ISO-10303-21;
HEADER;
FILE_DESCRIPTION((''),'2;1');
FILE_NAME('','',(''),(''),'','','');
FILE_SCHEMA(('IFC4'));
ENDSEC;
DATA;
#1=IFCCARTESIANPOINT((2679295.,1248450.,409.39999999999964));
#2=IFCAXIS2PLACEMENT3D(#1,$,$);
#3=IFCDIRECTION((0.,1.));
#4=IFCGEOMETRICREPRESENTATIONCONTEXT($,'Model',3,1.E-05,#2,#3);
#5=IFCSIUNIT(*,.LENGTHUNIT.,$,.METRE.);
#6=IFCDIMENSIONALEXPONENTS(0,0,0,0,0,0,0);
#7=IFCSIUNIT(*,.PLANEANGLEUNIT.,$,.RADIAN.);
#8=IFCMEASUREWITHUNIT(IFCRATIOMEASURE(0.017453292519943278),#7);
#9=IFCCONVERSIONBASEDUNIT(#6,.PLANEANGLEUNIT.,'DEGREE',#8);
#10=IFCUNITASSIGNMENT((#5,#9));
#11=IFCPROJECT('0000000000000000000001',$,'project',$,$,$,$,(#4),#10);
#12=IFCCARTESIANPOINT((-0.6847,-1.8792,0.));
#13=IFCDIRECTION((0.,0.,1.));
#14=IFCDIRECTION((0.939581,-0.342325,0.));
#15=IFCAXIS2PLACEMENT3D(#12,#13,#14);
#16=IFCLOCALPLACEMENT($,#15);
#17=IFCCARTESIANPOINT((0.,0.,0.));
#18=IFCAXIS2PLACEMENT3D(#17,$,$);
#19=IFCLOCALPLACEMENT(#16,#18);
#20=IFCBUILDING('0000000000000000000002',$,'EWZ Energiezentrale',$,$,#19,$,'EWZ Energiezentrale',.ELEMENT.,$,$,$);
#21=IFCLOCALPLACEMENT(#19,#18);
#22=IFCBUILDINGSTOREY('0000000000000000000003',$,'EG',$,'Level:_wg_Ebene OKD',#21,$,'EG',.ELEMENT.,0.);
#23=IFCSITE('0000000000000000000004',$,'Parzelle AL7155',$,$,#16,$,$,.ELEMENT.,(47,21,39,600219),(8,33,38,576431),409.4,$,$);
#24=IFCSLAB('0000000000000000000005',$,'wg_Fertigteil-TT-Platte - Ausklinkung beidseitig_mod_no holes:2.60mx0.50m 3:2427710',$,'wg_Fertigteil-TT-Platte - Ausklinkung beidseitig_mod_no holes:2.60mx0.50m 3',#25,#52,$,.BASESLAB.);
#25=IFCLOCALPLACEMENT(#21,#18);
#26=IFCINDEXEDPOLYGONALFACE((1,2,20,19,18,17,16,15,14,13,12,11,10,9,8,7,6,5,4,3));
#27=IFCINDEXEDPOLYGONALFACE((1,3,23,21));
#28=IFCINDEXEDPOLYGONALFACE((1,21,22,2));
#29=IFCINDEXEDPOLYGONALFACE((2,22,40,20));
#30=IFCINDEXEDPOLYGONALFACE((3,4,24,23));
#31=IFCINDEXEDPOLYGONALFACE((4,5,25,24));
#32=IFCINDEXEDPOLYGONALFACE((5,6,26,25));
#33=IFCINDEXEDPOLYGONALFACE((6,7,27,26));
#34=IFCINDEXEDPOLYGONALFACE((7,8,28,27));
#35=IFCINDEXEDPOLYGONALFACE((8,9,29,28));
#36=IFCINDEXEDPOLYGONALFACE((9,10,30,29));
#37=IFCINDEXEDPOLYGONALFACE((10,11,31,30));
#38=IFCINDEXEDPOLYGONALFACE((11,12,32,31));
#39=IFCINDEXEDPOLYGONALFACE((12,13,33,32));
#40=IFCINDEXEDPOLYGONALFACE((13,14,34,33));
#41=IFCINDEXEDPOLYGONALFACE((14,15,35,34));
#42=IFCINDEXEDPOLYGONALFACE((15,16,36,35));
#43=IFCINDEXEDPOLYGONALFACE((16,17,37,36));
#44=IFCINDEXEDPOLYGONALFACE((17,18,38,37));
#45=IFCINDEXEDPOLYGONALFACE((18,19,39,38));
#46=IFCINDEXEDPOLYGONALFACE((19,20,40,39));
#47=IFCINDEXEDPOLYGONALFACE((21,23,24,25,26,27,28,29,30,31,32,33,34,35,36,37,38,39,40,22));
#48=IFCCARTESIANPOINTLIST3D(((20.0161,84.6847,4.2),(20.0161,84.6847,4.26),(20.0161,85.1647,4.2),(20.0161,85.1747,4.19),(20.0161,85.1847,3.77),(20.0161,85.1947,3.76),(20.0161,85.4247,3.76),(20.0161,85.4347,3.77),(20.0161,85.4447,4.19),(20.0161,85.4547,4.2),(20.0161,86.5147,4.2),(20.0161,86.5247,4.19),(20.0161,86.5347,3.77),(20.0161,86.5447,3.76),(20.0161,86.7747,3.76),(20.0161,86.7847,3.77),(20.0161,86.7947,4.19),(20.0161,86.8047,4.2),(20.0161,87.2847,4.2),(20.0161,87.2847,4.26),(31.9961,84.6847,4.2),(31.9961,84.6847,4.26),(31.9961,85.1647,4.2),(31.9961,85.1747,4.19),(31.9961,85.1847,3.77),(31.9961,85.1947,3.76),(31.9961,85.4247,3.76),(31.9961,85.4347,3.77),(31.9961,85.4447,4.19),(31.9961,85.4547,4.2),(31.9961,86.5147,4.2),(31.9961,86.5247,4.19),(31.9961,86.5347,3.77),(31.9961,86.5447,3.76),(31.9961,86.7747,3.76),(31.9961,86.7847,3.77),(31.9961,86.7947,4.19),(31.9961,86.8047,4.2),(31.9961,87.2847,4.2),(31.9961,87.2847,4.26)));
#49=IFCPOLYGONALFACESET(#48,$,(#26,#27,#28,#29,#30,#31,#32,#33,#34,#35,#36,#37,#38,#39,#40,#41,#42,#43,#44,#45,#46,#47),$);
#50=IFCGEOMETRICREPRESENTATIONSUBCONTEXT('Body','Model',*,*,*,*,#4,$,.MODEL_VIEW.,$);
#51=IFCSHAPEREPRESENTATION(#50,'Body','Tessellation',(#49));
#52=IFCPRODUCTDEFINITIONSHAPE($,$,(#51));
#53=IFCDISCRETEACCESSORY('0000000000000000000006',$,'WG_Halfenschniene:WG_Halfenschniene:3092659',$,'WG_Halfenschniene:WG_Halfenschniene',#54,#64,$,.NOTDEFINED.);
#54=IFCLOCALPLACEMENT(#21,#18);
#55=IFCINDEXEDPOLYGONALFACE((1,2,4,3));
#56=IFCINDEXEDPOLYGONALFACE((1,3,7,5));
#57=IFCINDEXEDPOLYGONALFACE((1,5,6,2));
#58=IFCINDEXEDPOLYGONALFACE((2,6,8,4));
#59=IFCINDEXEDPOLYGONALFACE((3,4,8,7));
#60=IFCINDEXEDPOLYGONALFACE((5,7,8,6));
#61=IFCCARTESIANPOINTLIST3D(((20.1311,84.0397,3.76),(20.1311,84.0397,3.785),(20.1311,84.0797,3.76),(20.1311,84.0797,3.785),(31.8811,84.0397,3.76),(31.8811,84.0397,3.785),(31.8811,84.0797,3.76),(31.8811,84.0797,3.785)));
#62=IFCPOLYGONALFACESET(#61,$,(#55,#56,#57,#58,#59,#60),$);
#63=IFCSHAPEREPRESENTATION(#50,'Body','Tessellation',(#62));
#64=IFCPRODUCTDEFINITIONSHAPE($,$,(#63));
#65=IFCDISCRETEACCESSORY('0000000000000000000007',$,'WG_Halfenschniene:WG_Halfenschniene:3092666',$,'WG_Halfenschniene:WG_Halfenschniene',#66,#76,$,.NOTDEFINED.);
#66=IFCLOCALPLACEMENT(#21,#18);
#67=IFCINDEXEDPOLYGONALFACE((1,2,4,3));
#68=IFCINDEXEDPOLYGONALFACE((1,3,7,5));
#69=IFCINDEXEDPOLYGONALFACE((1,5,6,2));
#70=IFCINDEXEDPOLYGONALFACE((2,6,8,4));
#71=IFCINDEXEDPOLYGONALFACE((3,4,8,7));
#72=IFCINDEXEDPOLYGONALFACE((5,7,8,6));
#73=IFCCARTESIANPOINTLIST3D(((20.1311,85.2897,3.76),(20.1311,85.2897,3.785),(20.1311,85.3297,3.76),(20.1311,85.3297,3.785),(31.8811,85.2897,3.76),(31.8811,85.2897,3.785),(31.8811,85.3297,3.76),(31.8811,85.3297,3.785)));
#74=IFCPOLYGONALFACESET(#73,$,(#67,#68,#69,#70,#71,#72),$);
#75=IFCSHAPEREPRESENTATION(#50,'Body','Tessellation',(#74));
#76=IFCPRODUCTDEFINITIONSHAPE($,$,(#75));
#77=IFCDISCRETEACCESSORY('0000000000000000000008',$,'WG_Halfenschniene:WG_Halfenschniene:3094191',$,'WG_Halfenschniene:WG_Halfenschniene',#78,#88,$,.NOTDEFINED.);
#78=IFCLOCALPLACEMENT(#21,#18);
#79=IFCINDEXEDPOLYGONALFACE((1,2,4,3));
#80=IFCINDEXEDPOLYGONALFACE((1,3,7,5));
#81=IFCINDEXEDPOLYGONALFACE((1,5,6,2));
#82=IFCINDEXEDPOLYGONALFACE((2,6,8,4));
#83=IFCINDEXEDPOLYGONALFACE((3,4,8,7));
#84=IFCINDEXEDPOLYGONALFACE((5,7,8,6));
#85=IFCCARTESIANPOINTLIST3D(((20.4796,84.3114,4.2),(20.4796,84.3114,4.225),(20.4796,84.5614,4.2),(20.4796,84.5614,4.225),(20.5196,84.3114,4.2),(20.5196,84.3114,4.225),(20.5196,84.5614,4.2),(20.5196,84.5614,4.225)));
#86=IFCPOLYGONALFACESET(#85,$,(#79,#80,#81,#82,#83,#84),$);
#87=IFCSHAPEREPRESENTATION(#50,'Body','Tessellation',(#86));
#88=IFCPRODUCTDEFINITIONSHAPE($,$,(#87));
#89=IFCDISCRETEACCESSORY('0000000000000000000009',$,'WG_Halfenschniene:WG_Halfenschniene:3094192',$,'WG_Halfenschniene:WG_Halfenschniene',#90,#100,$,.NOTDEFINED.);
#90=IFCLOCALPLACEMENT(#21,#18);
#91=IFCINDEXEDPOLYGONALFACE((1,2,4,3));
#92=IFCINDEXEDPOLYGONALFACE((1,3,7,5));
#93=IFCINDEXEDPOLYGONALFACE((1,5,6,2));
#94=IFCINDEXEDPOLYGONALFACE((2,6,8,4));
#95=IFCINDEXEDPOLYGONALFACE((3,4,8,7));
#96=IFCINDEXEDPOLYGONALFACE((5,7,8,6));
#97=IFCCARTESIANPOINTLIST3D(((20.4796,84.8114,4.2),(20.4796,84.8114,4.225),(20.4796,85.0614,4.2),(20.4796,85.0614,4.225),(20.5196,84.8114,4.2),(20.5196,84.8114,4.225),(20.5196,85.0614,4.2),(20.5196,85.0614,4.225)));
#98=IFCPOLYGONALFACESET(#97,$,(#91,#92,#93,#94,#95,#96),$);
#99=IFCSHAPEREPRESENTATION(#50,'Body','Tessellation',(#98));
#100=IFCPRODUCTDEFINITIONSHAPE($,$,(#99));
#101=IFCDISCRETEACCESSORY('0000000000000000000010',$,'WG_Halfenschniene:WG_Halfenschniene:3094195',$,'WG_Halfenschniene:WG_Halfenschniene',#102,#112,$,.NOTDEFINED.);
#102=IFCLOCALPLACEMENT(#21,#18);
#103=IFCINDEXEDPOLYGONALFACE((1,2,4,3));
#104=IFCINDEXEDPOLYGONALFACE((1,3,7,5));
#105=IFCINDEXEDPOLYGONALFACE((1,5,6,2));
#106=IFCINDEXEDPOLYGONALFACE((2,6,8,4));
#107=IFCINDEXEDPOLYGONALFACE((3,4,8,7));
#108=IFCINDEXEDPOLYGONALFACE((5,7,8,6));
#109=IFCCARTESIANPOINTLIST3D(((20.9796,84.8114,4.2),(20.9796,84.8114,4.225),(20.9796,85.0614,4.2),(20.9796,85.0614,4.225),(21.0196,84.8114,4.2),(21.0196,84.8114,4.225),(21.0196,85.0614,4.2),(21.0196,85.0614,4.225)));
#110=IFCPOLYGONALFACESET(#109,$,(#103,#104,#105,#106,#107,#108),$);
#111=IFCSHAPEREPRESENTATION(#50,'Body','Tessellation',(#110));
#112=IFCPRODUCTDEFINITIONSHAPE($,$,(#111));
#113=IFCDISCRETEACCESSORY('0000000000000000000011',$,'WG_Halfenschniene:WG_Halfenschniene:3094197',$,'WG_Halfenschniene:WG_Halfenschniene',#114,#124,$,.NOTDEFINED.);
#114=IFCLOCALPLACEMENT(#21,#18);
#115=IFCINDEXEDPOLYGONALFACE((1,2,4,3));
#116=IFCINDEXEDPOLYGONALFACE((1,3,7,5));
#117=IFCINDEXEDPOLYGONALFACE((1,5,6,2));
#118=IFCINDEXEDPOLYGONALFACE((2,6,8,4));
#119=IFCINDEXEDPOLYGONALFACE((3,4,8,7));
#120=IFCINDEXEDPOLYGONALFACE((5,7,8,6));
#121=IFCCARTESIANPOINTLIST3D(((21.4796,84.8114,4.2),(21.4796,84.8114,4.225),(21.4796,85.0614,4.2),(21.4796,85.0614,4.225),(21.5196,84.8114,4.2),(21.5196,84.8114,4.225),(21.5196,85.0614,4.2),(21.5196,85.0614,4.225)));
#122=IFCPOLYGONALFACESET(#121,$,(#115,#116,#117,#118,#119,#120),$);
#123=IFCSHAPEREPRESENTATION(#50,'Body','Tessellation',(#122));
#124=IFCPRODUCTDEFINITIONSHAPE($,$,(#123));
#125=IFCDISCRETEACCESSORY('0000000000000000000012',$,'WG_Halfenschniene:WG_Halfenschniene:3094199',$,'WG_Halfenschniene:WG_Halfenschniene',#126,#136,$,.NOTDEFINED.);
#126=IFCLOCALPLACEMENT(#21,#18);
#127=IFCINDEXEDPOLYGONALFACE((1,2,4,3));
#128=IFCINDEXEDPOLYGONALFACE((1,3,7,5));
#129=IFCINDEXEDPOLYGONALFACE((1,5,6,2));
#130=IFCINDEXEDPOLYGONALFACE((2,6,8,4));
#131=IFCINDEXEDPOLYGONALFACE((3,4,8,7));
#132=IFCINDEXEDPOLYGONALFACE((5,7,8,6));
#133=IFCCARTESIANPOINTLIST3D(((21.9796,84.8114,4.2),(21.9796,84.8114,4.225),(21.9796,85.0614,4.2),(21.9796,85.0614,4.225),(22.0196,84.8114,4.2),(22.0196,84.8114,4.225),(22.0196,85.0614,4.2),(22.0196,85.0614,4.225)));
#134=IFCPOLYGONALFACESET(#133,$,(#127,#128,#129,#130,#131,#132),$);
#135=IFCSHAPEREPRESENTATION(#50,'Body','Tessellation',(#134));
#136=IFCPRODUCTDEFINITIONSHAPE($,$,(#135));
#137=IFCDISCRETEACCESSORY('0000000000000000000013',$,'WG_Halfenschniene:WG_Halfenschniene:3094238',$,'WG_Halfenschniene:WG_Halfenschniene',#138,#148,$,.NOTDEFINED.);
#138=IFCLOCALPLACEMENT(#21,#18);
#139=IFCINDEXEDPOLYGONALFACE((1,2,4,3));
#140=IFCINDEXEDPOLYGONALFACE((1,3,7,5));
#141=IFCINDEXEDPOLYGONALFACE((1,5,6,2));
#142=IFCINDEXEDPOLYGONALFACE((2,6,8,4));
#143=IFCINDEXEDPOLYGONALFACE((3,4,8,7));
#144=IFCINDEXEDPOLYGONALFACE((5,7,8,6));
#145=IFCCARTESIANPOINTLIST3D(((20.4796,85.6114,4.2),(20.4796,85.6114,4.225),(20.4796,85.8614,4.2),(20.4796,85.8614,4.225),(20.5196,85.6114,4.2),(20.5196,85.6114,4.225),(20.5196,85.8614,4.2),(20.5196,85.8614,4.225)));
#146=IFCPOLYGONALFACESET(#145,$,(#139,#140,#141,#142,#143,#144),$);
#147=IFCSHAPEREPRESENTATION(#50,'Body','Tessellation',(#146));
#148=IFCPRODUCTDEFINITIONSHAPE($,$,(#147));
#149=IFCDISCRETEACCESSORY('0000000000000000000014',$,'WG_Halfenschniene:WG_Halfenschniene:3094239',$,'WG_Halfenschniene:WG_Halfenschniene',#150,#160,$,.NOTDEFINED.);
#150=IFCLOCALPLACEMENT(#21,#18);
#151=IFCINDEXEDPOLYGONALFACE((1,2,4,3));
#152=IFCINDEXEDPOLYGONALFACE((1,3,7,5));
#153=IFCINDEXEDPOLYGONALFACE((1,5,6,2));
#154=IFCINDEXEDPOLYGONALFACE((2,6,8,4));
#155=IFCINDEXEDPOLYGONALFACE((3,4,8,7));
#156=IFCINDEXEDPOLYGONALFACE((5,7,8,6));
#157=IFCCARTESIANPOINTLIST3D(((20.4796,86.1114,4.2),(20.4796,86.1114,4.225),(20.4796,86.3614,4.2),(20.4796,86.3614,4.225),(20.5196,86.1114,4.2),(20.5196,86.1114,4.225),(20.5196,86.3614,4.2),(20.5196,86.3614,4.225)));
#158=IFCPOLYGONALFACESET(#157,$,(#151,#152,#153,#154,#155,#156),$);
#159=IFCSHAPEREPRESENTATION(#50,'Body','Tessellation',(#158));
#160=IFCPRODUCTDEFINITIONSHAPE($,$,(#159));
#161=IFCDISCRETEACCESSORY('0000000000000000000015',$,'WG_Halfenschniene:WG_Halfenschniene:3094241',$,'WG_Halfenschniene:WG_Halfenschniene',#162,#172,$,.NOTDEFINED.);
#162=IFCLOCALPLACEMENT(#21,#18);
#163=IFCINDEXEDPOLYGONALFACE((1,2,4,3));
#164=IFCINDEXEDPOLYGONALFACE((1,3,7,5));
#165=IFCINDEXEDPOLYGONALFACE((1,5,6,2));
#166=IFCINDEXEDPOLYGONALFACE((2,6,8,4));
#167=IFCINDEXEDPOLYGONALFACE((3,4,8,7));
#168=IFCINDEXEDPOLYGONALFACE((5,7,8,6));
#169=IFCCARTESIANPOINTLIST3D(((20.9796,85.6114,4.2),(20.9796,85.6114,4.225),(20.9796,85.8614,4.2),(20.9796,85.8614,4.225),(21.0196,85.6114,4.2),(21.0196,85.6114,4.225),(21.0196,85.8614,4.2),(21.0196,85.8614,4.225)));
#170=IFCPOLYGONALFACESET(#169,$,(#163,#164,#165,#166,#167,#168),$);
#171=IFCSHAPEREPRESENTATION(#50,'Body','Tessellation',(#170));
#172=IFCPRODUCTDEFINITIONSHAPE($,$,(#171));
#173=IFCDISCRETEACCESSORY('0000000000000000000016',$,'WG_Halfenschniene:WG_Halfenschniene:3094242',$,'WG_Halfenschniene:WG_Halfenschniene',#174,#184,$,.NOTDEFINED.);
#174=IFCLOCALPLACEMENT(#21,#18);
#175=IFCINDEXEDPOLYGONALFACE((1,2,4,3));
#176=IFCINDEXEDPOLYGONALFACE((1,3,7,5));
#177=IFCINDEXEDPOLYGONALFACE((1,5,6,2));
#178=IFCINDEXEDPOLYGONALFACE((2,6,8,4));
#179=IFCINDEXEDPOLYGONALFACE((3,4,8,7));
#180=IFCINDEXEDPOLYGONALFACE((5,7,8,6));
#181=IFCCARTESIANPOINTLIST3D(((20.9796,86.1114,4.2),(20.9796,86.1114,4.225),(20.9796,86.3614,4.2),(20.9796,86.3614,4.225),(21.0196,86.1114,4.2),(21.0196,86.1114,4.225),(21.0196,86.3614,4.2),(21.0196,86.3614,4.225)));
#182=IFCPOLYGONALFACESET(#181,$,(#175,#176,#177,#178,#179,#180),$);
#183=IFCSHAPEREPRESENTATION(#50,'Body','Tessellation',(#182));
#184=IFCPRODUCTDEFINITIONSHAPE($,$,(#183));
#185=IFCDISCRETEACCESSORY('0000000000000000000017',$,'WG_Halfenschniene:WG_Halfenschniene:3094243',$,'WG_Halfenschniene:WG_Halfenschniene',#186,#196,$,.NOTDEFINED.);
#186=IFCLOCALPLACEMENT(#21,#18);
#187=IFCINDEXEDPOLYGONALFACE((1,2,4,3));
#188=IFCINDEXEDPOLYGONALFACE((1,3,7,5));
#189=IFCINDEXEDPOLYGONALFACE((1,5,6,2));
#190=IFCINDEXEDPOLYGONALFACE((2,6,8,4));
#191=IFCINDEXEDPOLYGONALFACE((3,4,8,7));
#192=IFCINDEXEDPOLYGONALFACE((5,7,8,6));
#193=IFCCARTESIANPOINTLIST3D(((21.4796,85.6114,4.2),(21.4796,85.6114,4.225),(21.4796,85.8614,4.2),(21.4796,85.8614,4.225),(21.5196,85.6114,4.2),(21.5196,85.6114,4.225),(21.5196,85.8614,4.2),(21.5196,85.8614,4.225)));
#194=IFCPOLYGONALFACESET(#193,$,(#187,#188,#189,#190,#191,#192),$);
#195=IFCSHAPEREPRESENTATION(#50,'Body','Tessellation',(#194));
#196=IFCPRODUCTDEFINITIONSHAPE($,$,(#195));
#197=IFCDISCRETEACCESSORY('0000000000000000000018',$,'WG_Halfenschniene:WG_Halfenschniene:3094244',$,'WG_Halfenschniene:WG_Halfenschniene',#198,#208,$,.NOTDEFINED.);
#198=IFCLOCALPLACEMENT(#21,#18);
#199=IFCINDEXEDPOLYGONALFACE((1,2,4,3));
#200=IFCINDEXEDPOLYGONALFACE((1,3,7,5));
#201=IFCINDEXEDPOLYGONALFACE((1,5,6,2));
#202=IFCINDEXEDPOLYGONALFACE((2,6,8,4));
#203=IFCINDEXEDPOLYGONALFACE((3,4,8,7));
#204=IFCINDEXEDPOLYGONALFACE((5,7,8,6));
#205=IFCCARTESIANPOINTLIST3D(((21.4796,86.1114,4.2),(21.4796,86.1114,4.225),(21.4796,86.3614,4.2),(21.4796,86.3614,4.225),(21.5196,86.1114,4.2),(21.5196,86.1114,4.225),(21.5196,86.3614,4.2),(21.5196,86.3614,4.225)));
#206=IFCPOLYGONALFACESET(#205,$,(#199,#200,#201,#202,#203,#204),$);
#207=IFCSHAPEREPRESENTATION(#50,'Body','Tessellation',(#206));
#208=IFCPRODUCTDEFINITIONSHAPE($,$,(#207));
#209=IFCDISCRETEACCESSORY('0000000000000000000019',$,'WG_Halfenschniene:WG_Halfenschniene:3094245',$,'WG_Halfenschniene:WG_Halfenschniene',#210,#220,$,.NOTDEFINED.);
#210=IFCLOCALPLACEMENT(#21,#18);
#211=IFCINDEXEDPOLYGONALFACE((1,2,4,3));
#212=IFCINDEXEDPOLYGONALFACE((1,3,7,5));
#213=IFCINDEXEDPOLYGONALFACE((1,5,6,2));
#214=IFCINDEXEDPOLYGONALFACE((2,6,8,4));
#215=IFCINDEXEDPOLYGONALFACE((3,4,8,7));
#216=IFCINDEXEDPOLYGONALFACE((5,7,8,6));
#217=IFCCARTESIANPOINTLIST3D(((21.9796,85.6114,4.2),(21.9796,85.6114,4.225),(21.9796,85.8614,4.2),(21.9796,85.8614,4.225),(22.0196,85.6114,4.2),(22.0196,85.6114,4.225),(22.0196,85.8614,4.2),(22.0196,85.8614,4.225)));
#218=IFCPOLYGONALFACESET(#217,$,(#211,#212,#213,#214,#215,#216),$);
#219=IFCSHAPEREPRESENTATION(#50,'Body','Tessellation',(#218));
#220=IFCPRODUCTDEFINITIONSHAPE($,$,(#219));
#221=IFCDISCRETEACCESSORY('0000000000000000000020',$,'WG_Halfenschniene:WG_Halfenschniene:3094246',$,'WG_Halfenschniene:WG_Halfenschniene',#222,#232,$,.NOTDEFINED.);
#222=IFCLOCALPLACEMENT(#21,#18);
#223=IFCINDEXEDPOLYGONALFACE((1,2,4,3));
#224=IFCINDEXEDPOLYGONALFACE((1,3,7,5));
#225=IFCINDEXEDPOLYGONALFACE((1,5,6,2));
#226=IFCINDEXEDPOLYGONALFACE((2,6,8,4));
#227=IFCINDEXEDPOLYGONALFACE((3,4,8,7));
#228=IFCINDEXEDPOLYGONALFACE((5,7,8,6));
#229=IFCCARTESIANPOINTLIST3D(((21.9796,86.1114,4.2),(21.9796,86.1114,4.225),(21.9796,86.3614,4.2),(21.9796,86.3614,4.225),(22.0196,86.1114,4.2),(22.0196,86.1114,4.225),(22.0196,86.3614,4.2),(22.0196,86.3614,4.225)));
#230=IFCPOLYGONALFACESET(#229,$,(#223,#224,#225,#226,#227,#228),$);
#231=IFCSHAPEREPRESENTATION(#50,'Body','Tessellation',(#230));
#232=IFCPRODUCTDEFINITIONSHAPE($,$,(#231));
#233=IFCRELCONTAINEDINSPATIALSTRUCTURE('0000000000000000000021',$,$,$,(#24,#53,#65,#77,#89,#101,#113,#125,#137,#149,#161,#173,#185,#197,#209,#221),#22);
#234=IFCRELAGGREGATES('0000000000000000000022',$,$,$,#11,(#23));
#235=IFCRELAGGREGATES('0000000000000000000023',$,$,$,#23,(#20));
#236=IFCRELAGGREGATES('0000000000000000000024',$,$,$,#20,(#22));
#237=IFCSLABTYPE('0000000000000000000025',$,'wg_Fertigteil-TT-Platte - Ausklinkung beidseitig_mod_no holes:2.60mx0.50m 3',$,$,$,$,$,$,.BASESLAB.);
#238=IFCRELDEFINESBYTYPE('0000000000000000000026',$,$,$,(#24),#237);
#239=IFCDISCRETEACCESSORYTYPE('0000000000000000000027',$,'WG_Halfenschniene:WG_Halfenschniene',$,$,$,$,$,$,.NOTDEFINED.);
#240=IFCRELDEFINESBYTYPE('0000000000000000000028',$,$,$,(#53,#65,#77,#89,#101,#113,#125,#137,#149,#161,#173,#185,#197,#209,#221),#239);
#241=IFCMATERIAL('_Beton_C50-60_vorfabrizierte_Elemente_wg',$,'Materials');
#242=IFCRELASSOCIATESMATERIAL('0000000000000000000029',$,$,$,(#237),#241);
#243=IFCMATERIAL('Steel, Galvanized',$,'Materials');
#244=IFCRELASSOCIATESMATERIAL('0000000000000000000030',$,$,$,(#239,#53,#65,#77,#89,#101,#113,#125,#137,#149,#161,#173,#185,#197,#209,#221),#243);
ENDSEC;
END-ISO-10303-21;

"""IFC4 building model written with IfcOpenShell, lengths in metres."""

from ifc_helpers import new_model, entity, si_unit, converted_unit, direction, frame, origin, place, context, subcontext, project, spatial, indexed_curve, outline, extrude, source, transform, mapped, material, type_object, type_shapes, element, save


model = new_model("IFC4")

# Units and contexts
model_context = context("Model", 3, precision=1e-05, world=frame((2679295.0, 1248450.0, 409.39999999999964)), true_north=direction((0.0, 1.0)))
body_context = subcontext(model_context, "Body", "Model", "MODEL_VIEW")
ifc_project = project(units=[si_unit("LENGTHUNIT", "METRE"), converted_unit("PLANEANGLEUNIT", "DEGREE", entity("IfcRatioMeasure", 0.017453292519943278), si_unit("PLANEANGLEUNIT", "RADIAN"), dimensions=[0, 0, 0, 0, 0, 0, 0])], contexts=[model_context])

# Site, building, storey
site_placement = place(None, frame((-0.6847, -1.8792, 0.0), z_axis=(0.0, 0.0, 1.0), x_axis=(0.939581, -0.342325, 0.0)))
site = spatial("IfcSite", under=ifc_project, at=site_placement, Name="Parzelle AL7155", CompositionType="ELEMENT", RefLatitude=(47, 21, 39, 600219), RefLongitude=(8, 33, 38, 576431), RefElevation=409.4)
building_placement = place(site_placement, origin())
building = spatial("IfcBuilding", under=site, at=building_placement, Name="EWZ Energiezentrale", LongName="EWZ Energiezentrale", CompositionType="ELEMENT")
storey_placement = place(building_placement, origin())
storey = spatial("IfcBuildingStorey", under=building, at=storey_placement, Name="EG", ObjectType="Level:_wg_Ebene OKD", LongName="EG", CompositionType="ELEMENT", Elevation=0.0)

# Slab
ifc_material_1 = material(Name="_Beton_C50-60_vorfabrizierte_Elemente_wg", Category="Materials")
slab_type = type_object("IfcSlabType", Name="wg_Fertigteil-TT-Platte - Ausklinkung beidseitig_mod_no holes:2.60mx0.50m 3", PredefinedType="BASESLAB", material=ifc_material_1)
slab_placement = place(storey_placement, frame((20.0161, 84.6847, 3.76), z_axis=(0.0, 0.0, 1.0), x_axis=(1.0, 0.0, 0.0)))
element("IfcSlab", 1, at=slab_placement, inside=storey, type_object=slab_type, Name="wg_Fertigteil-TT-Platte - Ausklinkung beidseitig_mod_no holes:2.60mx0.50m 3:2427710", ObjectType="wg_Fertigteil-TT-Platte - Ausklinkung beidseitig_mod_no holes:2.60mx0.50m 3", PredefinedType="BASESLAB", context=body_context, shape_type="SweptSolid", body=[
    extrude(outline(indexed_curve([(-1.3, -0.23), (1.3, -0.23), (1.3, -0.17), (0.82, -0.17), (0.81, -0.16), (0.8, 0.26), (0.79, 0.27), (0.56, 0.27), (0.55, 0.26), (0.54, -0.16), (0.53, -0.17), (-0.53, -0.17), (-0.54, -0.16), (-0.55, 0.26), (-0.56, 0.27), (-0.79, 0.27), (-0.8, 0.26), (-0.81, -0.16), (-0.82, -0.17), (-1.3, -0.17), (-1.3, -0.23)], self_intersect=False)), frame((0.0, 1.3, 0.27), z_axis=(1.0, 0.0, 0.0), x_axis=(0.0, -1.0, 0.0)), (0.0, 0.0, 1.0), 11.98),
])

# Discrete accessories
ifc_material_2 = material(Name="Steel, Galvanized", Category="Materials")
discrete_accessory_type = type_object("IfcDiscreteAccessoryType", Name="WG_Halfenschniene:WG_Halfenschniene", PredefinedType="NOTDEFINED", material=ifc_material_2)
shared_shape_1 = source(origin(), body_context, "Body", "SweptSolid", [
    extrude(outline(indexed_curve([(-5.875, -0.02), (5.875, -0.02), (5.875, 0.02), (-5.875, 0.02), (-5.875, -0.02)], self_intersect=False)), frame((5.875, 0.0, -0.0125)), (0.0, 0.0, 1.0), 0.025),
])
type_shapes(discrete_accessory_type, [shared_shape_1])
for number, where, z_axis, x_axis, name in (
    (2, (20.1311, 84.0597, 3.7725), (0.0, 0.0, -1.0), (1.0, 0.0, 0.0), "WG_Halfenschniene:WG_Halfenschniene:3092659"),
    (3, (20.1311, 85.3097, 3.7725), (0.0, 0.0, -1.0), (1.0, 0.0, 0.0), "WG_Halfenschniene:WG_Halfenschniene:3092666"),
):
    element("IfcDiscreteAccessory", number, at=place(storey_placement, frame(where, z_axis=z_axis, x_axis=x_axis)), inside=storey, type_object=discrete_accessory_type, material=ifc_material_2, Name=name, ObjectType="WG_Halfenschniene:WG_Halfenschniene", PredefinedType="NOTDEFINED", context=body_context, shape_type="MappedRepresentation", body=[
        mapped(shared_shape_1, transform((0.0, 0.0, 0.0), scale=1.0)),
    ])
shared_shape_2 = source(origin(), body_context, "Body", "SweptSolid", [
    extrude(outline(indexed_curve([(-0.125, -0.02), (0.125, -0.02), (0.125, 0.02), (-0.125, 0.02), (-0.125, -0.02)], self_intersect=False)), frame((0.125, 0.0, -0.0125)), (0.0, 0.0, 1.0), 0.025),
])
for number, where, z_axis, x_axis, name in (
    (4, (20.4996, 84.3114, 4.2125), (0.0, 0.0, -1.0), (0.0, 1.0, 0.0), "WG_Halfenschniene:WG_Halfenschniene:3094191"),
    (5, (20.4996, 84.8114, 4.2125), (0.0, 0.0, -1.0), (0.0, 1.0, 0.0), "WG_Halfenschniene:WG_Halfenschniene:3094192"),
    (6, (20.9996, 84.8114, 4.2125), (0.0, 0.0, -1.0), (0.0, 1.0, 0.0), "WG_Halfenschniene:WG_Halfenschniene:3094195"),
    (7, (21.4996, 84.8114, 4.2125), (0.0, 0.0, -1.0), (0.0, 1.0, 0.0), "WG_Halfenschniene:WG_Halfenschniene:3094197"),
    (8, (21.9996, 84.8114, 4.2125), (0.0, 0.0, -1.0), (0.0, 1.0, 0.0), "WG_Halfenschniene:WG_Halfenschniene:3094199"),
    (9, (20.4996, 85.6114, 4.2125), (0.0, 0.0, -1.0), (0.0, 1.0, 0.0), "WG_Halfenschniene:WG_Halfenschniene:3094238"),
    (10, (20.4996, 86.1114, 4.2125), (0.0, 0.0, -1.0), (0.0, 1.0, 0.0), "WG_Halfenschniene:WG_Halfenschniene:3094239"),
    (11, (20.9996, 85.6114, 4.2125), (0.0, 0.0, -1.0), (0.0, 1.0, 0.0), "WG_Halfenschniene:WG_Halfenschniene:3094241"),
    (12, (20.9996, 86.1114, 4.2125), (0.0, 0.0, -1.0), (0.0, 1.0, 0.0), "WG_Halfenschniene:WG_Halfenschniene:3094242"),
    (13, (21.4996, 85.6114, 4.2125), (0.0, 0.0, -1.0), (0.0, 1.0, 0.0), "WG_Halfenschniene:WG_Halfenschniene:3094243"),
    (14, (21.4996, 86.1114, 4.2125), (0.0, 0.0, -1.0), (0.0, 1.0, 0.0), "WG_Halfenschniene:WG_Halfenschniene:3094244"),
    (15, (21.9996, 85.6114, 4.2125), (0.0, 0.0, -1.0), (0.0, 1.0, 0.0), "WG_Halfenschniene:WG_Halfenschniene:3094245"),
    (16, (21.9996, 86.1114, 4.2125), (0.0, 0.0, -1.0), (0.0, 1.0, 0.0), "WG_Halfenschniene:WG_Halfenschniene:3094246"),
):
    element("IfcDiscreteAccessory", number, at=place(storey_placement, frame(where, z_axis=z_axis, x_axis=x_axis)), inside=storey, type_object=discrete_accessory_type, material=ifc_material_2, Name=name, ObjectType="WG_Halfenschniene:WG_Halfenschniene", PredefinedType="NOTDEFINED", context=body_context, shape_type="MappedRepresentation", body=[
        mapped(shared_shape_2, transform((0.0, 0.0, 0.0), scale=1.0)),
    ])

save(model, "model.ifc")
